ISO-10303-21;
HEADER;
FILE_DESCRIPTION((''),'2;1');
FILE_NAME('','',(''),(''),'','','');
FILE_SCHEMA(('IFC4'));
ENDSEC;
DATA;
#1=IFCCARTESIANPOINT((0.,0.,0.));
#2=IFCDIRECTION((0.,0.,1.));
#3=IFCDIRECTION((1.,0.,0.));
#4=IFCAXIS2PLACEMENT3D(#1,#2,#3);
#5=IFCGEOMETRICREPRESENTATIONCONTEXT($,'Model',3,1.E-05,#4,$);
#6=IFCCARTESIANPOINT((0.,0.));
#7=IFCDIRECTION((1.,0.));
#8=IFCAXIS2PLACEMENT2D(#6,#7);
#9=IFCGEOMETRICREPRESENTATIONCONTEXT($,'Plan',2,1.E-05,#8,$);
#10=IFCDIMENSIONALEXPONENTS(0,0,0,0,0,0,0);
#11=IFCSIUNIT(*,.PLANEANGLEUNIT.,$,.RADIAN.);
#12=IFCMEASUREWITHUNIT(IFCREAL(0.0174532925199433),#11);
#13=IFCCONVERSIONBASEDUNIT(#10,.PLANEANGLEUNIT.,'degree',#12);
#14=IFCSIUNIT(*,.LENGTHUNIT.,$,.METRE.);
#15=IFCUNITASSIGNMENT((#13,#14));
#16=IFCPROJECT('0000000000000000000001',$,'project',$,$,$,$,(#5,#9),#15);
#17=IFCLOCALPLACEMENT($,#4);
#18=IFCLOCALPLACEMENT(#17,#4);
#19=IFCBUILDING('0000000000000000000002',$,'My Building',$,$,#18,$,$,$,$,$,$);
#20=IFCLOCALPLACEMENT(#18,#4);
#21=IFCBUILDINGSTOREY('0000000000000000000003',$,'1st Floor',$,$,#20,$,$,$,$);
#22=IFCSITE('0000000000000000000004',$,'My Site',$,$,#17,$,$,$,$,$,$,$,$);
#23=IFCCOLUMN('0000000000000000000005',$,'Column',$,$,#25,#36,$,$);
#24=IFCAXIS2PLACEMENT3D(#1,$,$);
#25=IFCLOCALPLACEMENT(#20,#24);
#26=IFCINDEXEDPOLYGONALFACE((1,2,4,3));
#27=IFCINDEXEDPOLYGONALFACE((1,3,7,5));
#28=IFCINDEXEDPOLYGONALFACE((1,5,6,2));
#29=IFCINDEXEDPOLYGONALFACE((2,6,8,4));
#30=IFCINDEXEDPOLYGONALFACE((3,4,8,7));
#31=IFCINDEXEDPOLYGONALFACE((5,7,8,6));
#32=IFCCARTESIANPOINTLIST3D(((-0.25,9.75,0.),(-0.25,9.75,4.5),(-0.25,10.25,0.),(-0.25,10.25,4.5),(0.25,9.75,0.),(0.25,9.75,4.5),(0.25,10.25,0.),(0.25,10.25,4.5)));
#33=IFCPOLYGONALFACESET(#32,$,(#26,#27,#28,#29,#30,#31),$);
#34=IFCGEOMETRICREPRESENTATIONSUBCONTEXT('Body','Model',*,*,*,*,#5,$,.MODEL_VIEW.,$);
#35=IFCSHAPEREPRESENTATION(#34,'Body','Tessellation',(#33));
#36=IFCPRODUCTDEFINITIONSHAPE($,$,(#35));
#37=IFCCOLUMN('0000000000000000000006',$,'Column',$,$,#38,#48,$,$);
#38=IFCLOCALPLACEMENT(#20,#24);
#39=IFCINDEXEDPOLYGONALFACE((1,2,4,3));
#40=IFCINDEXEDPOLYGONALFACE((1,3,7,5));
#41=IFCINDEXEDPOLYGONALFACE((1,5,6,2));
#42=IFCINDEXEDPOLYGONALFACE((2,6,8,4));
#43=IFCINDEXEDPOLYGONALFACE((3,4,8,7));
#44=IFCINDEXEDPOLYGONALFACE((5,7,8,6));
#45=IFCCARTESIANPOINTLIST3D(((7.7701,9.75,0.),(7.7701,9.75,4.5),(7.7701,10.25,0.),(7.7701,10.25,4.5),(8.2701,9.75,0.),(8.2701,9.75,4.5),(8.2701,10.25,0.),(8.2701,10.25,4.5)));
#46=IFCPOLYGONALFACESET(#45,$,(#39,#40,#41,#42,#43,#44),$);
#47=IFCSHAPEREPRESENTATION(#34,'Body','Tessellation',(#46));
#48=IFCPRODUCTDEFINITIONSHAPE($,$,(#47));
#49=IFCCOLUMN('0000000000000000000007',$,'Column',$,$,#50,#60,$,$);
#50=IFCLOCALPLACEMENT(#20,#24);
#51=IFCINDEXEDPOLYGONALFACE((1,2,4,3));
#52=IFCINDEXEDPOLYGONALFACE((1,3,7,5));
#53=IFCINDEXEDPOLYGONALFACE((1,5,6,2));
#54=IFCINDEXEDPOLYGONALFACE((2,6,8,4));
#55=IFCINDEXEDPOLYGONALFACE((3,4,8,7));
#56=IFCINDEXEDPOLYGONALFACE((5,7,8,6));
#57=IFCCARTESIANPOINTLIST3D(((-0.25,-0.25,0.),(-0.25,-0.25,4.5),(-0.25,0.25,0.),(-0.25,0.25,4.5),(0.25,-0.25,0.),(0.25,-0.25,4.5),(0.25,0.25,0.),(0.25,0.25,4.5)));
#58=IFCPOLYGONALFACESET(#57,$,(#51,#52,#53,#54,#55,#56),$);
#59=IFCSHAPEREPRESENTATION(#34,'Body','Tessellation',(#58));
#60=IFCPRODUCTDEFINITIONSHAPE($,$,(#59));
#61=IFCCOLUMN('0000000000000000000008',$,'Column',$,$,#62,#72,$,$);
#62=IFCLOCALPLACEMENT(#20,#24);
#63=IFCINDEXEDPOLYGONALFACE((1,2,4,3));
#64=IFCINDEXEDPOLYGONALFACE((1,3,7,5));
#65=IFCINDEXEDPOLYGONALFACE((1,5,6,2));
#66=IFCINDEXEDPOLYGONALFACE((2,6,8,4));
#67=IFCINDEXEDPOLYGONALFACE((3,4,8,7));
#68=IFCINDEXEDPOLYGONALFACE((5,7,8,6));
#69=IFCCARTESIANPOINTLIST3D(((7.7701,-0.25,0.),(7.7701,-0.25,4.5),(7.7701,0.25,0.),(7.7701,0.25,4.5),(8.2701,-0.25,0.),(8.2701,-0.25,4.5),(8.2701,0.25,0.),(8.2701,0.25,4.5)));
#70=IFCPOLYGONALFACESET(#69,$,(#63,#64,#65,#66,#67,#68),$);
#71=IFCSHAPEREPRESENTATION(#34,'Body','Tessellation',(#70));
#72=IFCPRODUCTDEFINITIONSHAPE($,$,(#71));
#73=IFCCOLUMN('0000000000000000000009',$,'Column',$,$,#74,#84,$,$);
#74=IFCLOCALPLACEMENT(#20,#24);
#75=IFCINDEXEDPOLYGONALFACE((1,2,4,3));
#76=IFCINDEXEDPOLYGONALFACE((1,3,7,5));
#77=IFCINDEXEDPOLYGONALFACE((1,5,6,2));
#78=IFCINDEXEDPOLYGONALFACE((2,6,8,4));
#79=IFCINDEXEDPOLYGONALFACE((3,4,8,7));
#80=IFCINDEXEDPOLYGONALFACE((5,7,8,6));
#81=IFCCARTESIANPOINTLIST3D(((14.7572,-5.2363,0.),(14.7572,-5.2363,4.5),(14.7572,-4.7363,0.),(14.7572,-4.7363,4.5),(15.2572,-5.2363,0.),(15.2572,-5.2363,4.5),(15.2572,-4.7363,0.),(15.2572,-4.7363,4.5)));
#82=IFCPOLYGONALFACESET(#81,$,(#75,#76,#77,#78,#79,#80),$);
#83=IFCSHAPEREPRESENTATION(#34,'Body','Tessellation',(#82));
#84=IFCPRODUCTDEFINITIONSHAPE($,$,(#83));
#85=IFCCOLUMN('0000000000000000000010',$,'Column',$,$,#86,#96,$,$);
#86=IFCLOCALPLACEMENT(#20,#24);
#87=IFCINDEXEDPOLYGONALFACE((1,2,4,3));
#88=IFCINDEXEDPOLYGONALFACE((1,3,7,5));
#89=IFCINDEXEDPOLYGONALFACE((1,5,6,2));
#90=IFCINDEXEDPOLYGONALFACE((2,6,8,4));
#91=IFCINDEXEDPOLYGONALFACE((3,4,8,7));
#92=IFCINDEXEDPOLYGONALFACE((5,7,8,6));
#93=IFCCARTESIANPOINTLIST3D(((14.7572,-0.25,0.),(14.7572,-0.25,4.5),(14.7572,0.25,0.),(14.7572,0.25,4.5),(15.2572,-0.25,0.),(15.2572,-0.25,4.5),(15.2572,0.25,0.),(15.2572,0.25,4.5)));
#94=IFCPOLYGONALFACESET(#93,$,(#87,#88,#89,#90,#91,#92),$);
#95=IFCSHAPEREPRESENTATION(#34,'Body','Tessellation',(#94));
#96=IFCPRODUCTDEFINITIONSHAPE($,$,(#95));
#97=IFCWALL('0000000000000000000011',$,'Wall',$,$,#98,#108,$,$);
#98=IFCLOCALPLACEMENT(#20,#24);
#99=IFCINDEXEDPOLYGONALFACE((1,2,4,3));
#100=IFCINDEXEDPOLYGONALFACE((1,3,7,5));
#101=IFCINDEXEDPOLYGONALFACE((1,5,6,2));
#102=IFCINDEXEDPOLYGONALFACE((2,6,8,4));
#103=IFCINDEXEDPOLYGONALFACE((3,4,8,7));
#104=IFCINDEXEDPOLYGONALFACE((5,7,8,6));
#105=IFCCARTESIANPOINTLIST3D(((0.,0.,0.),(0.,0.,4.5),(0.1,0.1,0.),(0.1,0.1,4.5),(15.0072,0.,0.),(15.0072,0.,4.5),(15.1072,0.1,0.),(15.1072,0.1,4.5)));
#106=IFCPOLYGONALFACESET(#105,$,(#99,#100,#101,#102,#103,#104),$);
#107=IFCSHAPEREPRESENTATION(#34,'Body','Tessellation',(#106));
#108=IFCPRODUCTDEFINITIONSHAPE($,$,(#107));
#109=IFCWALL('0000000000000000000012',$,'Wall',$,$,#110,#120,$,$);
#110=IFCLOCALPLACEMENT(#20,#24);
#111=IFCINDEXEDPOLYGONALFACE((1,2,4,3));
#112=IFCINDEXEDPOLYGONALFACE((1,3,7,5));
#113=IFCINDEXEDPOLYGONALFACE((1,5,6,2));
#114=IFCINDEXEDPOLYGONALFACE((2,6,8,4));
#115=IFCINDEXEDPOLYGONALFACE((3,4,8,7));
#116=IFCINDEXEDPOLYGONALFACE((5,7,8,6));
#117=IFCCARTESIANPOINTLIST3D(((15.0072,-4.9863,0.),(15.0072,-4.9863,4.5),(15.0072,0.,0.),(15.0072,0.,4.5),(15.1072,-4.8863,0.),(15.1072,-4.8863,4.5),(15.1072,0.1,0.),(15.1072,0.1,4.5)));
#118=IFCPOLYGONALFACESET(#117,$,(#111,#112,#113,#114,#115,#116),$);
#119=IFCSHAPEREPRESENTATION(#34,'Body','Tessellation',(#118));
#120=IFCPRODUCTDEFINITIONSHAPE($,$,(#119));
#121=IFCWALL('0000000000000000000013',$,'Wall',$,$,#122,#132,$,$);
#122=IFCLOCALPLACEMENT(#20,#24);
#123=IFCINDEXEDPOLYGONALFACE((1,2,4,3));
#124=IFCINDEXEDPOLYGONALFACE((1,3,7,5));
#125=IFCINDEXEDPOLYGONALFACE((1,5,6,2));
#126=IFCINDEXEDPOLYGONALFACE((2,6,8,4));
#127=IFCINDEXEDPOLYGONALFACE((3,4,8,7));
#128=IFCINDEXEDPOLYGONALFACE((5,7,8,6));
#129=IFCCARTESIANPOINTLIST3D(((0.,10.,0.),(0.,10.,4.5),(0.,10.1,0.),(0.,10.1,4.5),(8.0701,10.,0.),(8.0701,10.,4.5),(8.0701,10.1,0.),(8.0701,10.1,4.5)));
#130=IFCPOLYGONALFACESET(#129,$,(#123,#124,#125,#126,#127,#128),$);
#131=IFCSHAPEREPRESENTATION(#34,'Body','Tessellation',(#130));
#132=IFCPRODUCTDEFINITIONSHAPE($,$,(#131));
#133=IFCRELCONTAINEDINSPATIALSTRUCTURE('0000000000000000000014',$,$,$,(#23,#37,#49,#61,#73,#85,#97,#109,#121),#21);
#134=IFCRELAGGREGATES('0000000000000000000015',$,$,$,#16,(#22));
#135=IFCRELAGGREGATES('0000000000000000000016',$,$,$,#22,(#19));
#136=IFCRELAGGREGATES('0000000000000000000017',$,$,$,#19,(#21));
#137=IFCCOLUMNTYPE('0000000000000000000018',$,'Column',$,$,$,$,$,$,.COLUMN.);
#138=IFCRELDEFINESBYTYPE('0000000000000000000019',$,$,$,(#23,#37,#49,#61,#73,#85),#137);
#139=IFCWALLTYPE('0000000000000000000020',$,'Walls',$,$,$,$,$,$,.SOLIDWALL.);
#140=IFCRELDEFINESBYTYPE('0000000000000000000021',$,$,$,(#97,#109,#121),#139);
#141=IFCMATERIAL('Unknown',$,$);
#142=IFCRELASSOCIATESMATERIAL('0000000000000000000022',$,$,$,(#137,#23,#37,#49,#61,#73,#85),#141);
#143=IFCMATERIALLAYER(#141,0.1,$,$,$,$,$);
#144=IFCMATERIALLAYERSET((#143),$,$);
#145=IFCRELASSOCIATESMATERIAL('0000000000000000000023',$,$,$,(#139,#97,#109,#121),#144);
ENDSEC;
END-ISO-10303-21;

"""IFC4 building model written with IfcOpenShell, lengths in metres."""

from ifc_helpers import new_model, entity, si_unit, converted_unit, frame, origin_with_axes, origin_2d_with_axis, place, context, subcontext, project, spatial, line, indexed_curve, rectangle, outline, extrude, material, layer, layer_set, layer_usage, material_profile, profile_set, profile_usage, type_object, element, save


model = new_model("IFC4")

# Units and contexts
model_context = context("Model", 3, precision=1e-05, world=origin_with_axes())
plan_context = context("Plan", 2, precision=1e-05, world=origin_2d_with_axis())
body_context_1 = subcontext(model_context, "Body", "Model", "MODEL_VIEW")
ifc_project = project(units=[converted_unit("PLANEANGLEUNIT", "degree", entity("IfcReal", 0.0174532925199433), si_unit("PLANEANGLEUNIT", "RADIAN"), dimensions=[0, 0, 0, 0, 0, 0, 0]), si_unit("LENGTHUNIT", "METRE")], contexts=[model_context, plan_context])

# Site, building, storey
site_placement = place(None, origin_with_axes())
site = spatial("IfcSite", under=ifc_project, at=site_placement, Name="My Site")
building_placement = place(site_placement, origin_with_axes())
building = spatial("IfcBuilding", under=site, at=building_placement, Name="My Building")
storey_placement = place(building_placement, origin_with_axes())
storey = spatial("IfcBuildingStorey", under=building, at=storey_placement, Name="1st Floor")

# Columns
ifc_material = material(Name="Unknown")
ifc_material_profile = material_profile(ifc_material, rectangle(XDim=0.5, YDim=0.5))
ifc_profile_set = profile_set([ifc_material_profile])
ifc_profile_usage_1 = profile_usage(ifc_profile_set, cardinal=5)
column_type = type_object("IfcColumnType", Name="Column", PredefinedType="COLUMN", material=ifc_profile_set)
column_1_placement = place(storey_placement, frame((0.0, 10.0, 0.0), z_axis=(0.0, 0.0, 1.0), x_axis=(1.0, 0.0, 0.0)))
element("IfcColumn", 1, at=column_1_placement, inside=storey, type_object=column_type, material=ifc_profile_usage_1, Name="Column", context=body_context_1, shape_type="SweptSolid", body=[
    extrude(rectangle(XDim=0.5, YDim=0.5), origin_with_axes(), (0.0, 0.0, 1.0), 4.5),
])
ifc_profile_usage_2 = profile_usage(ifc_profile_set, cardinal=5)
column_2_placement = place(storey_placement, frame((8.0201, 10.0, 0.0), z_axis=(0.0, 0.0, 1.0), x_axis=(1.0, 0.0, 0.0)))
element("IfcColumn", 2, at=column_2_placement, inside=storey, type_object=column_type, material=ifc_profile_usage_2, Name="Column", context=body_context_1, shape_type="SweptSolid", body=[
    extrude(rectangle(XDim=0.5, YDim=0.5), origin_with_axes(), (0.0, 0.0, 1.0), 4.5),
])
ifc_profile_usage_3 = profile_usage(ifc_profile_set, cardinal=5)
column_3_placement = place(storey_placement, origin_with_axes())
element("IfcColumn", 3, at=column_3_placement, inside=storey, type_object=column_type, material=ifc_profile_usage_3, Name="Column", context=body_context_1, shape_type="SweptSolid", body=[
    extrude(rectangle(XDim=0.5, YDim=0.5), origin_with_axes(), (0.0, 0.0, 1.0), 4.5),
])
ifc_profile_usage_4 = profile_usage(ifc_profile_set, cardinal=5)
column_4_placement = place(storey_placement, frame((8.0201, 0.0, 0.0), z_axis=(0.0, 0.0, 1.0), x_axis=(1.0, 0.0, 0.0)))
element("IfcColumn", 4, at=column_4_placement, inside=storey, type_object=column_type, material=ifc_profile_usage_4, Name="Column", context=body_context_1, shape_type="SweptSolid", body=[
    extrude(rectangle(XDim=0.5, YDim=0.5), origin_with_axes(), (0.0, 0.0, 1.0), 4.5),
])
ifc_profile_usage_5 = profile_usage(ifc_profile_set, cardinal=5)
column_5_placement = place(storey_placement, frame((15.0072, -4.9863, 0.0), z_axis=(0.0, 0.0, 1.0), x_axis=(1.0, 0.0, 0.0)))
element("IfcColumn", 5, at=column_5_placement, inside=storey, type_object=column_type, material=ifc_profile_usage_5, Name="Column", context=body_context_1, shape_type="SweptSolid", body=[
    extrude(rectangle(XDim=0.5, YDim=0.5), origin_with_axes(), (0.0, 0.0, 1.0), 4.5),
])
ifc_profile_usage_6 = profile_usage(ifc_profile_set, cardinal=5)
column_6_placement = place(storey_placement, frame((15.0072, 0.0, 0.0), z_axis=(0.0, 0.0, 1.0), x_axis=(1.0, 0.0, 0.0)))
element("IfcColumn", 6, at=column_6_placement, inside=storey, type_object=column_type, material=ifc_profile_usage_6, Name="Column", context=body_context_1, shape_type="SweptSolid", body=[
    extrude(rectangle(XDim=0.5, YDim=0.5), origin_with_axes(), (0.0, 0.0, 1.0), 4.5),
])

# Walls
ifc_layer_1 = layer(ifc_material, 0.1)
ifc_layer_set_1 = layer_set([ifc_layer_1])
ifc_layer_usage_1 = layer_usage(ifc_layer_set_1, "AXIS2", "POSITIVE", 0.0)
wall_type_1 = type_object("IfcWallType", Name="Walls", PredefinedType="SOLIDWALL", material=ifc_layer_set_1)
wall_1_placement = place(storey_placement, frame((0.0, 0.0, 0.0), z_axis=(0.0, 0.0, 1.0), x_axis=(1.0, 0.0, 0.0)))
element("IfcWall", 7, at=wall_1_placement, inside=storey, type_object=wall_type_1, material=ifc_layer_usage_1, Name="Wall", context=body_context_1, shape_type="SweptSolid", body=[
    extrude(outline(indexed_curve([(0.0, 0.0), (0.1, 0.1), (15.1072, 0.1), (15.0072, 0.0)], segments=[line(1, 2, 3, 4, 1)])), origin_with_axes(), (0.0, 0.0, 1.0), 4.5),
])
ifc_layer_usage_2 = layer_usage(ifc_layer_set_1, "AXIS2", "POSITIVE", 0.0)
wall_2_placement = place(storey_placement, frame((15.0072, 0.0, 0.0), z_axis=(0.0, 0.0, 1.0), x_axis=(0.0, -1.0, 0.0)))
element("IfcWall", 8, at=wall_2_placement, inside=storey, type_object=wall_type_1, material=ifc_layer_usage_2, Name="Wall", context=body_context_1, shape_type="SweptSolid", body=[
    extrude(outline(indexed_curve([(0.0, 0.0), (-0.1, 0.1), (4.8863, 0.1), (4.9863, 0.0)], segments=[line(1, 2, 3, 4, 1)])), origin_with_axes(), (0.0, 0.0, 1.0), 4.5),
])

# Wall
ifc_layer_usage_3 = layer_usage(ifc_layer_set_1, "AXIS2", "POSITIVE", 0.0)
wall_3_placement = place(storey_placement, frame((0.0, 10.0, 0.0), z_axis=(0.0, 0.0, 1.0), x_axis=(1.0, 0.0, 0.0)))
element("IfcWall", 9, at=wall_3_placement, inside=storey, type_object=wall_type_1, material=ifc_layer_usage_3, Name="Wall", context=body_context_1, shape_type="SweptSolid", body=[
    extrude(outline(indexed_curve([(0.0, 0.0), (0.0, 0.1), (8.0701, 0.1), (8.0701, 0.0)], segments=[line(1, 2, 3, 4, 1)])), origin_with_axes(), (0.0, 0.0, 1.0), 4.5),
])

save(model, "model.ifc")
